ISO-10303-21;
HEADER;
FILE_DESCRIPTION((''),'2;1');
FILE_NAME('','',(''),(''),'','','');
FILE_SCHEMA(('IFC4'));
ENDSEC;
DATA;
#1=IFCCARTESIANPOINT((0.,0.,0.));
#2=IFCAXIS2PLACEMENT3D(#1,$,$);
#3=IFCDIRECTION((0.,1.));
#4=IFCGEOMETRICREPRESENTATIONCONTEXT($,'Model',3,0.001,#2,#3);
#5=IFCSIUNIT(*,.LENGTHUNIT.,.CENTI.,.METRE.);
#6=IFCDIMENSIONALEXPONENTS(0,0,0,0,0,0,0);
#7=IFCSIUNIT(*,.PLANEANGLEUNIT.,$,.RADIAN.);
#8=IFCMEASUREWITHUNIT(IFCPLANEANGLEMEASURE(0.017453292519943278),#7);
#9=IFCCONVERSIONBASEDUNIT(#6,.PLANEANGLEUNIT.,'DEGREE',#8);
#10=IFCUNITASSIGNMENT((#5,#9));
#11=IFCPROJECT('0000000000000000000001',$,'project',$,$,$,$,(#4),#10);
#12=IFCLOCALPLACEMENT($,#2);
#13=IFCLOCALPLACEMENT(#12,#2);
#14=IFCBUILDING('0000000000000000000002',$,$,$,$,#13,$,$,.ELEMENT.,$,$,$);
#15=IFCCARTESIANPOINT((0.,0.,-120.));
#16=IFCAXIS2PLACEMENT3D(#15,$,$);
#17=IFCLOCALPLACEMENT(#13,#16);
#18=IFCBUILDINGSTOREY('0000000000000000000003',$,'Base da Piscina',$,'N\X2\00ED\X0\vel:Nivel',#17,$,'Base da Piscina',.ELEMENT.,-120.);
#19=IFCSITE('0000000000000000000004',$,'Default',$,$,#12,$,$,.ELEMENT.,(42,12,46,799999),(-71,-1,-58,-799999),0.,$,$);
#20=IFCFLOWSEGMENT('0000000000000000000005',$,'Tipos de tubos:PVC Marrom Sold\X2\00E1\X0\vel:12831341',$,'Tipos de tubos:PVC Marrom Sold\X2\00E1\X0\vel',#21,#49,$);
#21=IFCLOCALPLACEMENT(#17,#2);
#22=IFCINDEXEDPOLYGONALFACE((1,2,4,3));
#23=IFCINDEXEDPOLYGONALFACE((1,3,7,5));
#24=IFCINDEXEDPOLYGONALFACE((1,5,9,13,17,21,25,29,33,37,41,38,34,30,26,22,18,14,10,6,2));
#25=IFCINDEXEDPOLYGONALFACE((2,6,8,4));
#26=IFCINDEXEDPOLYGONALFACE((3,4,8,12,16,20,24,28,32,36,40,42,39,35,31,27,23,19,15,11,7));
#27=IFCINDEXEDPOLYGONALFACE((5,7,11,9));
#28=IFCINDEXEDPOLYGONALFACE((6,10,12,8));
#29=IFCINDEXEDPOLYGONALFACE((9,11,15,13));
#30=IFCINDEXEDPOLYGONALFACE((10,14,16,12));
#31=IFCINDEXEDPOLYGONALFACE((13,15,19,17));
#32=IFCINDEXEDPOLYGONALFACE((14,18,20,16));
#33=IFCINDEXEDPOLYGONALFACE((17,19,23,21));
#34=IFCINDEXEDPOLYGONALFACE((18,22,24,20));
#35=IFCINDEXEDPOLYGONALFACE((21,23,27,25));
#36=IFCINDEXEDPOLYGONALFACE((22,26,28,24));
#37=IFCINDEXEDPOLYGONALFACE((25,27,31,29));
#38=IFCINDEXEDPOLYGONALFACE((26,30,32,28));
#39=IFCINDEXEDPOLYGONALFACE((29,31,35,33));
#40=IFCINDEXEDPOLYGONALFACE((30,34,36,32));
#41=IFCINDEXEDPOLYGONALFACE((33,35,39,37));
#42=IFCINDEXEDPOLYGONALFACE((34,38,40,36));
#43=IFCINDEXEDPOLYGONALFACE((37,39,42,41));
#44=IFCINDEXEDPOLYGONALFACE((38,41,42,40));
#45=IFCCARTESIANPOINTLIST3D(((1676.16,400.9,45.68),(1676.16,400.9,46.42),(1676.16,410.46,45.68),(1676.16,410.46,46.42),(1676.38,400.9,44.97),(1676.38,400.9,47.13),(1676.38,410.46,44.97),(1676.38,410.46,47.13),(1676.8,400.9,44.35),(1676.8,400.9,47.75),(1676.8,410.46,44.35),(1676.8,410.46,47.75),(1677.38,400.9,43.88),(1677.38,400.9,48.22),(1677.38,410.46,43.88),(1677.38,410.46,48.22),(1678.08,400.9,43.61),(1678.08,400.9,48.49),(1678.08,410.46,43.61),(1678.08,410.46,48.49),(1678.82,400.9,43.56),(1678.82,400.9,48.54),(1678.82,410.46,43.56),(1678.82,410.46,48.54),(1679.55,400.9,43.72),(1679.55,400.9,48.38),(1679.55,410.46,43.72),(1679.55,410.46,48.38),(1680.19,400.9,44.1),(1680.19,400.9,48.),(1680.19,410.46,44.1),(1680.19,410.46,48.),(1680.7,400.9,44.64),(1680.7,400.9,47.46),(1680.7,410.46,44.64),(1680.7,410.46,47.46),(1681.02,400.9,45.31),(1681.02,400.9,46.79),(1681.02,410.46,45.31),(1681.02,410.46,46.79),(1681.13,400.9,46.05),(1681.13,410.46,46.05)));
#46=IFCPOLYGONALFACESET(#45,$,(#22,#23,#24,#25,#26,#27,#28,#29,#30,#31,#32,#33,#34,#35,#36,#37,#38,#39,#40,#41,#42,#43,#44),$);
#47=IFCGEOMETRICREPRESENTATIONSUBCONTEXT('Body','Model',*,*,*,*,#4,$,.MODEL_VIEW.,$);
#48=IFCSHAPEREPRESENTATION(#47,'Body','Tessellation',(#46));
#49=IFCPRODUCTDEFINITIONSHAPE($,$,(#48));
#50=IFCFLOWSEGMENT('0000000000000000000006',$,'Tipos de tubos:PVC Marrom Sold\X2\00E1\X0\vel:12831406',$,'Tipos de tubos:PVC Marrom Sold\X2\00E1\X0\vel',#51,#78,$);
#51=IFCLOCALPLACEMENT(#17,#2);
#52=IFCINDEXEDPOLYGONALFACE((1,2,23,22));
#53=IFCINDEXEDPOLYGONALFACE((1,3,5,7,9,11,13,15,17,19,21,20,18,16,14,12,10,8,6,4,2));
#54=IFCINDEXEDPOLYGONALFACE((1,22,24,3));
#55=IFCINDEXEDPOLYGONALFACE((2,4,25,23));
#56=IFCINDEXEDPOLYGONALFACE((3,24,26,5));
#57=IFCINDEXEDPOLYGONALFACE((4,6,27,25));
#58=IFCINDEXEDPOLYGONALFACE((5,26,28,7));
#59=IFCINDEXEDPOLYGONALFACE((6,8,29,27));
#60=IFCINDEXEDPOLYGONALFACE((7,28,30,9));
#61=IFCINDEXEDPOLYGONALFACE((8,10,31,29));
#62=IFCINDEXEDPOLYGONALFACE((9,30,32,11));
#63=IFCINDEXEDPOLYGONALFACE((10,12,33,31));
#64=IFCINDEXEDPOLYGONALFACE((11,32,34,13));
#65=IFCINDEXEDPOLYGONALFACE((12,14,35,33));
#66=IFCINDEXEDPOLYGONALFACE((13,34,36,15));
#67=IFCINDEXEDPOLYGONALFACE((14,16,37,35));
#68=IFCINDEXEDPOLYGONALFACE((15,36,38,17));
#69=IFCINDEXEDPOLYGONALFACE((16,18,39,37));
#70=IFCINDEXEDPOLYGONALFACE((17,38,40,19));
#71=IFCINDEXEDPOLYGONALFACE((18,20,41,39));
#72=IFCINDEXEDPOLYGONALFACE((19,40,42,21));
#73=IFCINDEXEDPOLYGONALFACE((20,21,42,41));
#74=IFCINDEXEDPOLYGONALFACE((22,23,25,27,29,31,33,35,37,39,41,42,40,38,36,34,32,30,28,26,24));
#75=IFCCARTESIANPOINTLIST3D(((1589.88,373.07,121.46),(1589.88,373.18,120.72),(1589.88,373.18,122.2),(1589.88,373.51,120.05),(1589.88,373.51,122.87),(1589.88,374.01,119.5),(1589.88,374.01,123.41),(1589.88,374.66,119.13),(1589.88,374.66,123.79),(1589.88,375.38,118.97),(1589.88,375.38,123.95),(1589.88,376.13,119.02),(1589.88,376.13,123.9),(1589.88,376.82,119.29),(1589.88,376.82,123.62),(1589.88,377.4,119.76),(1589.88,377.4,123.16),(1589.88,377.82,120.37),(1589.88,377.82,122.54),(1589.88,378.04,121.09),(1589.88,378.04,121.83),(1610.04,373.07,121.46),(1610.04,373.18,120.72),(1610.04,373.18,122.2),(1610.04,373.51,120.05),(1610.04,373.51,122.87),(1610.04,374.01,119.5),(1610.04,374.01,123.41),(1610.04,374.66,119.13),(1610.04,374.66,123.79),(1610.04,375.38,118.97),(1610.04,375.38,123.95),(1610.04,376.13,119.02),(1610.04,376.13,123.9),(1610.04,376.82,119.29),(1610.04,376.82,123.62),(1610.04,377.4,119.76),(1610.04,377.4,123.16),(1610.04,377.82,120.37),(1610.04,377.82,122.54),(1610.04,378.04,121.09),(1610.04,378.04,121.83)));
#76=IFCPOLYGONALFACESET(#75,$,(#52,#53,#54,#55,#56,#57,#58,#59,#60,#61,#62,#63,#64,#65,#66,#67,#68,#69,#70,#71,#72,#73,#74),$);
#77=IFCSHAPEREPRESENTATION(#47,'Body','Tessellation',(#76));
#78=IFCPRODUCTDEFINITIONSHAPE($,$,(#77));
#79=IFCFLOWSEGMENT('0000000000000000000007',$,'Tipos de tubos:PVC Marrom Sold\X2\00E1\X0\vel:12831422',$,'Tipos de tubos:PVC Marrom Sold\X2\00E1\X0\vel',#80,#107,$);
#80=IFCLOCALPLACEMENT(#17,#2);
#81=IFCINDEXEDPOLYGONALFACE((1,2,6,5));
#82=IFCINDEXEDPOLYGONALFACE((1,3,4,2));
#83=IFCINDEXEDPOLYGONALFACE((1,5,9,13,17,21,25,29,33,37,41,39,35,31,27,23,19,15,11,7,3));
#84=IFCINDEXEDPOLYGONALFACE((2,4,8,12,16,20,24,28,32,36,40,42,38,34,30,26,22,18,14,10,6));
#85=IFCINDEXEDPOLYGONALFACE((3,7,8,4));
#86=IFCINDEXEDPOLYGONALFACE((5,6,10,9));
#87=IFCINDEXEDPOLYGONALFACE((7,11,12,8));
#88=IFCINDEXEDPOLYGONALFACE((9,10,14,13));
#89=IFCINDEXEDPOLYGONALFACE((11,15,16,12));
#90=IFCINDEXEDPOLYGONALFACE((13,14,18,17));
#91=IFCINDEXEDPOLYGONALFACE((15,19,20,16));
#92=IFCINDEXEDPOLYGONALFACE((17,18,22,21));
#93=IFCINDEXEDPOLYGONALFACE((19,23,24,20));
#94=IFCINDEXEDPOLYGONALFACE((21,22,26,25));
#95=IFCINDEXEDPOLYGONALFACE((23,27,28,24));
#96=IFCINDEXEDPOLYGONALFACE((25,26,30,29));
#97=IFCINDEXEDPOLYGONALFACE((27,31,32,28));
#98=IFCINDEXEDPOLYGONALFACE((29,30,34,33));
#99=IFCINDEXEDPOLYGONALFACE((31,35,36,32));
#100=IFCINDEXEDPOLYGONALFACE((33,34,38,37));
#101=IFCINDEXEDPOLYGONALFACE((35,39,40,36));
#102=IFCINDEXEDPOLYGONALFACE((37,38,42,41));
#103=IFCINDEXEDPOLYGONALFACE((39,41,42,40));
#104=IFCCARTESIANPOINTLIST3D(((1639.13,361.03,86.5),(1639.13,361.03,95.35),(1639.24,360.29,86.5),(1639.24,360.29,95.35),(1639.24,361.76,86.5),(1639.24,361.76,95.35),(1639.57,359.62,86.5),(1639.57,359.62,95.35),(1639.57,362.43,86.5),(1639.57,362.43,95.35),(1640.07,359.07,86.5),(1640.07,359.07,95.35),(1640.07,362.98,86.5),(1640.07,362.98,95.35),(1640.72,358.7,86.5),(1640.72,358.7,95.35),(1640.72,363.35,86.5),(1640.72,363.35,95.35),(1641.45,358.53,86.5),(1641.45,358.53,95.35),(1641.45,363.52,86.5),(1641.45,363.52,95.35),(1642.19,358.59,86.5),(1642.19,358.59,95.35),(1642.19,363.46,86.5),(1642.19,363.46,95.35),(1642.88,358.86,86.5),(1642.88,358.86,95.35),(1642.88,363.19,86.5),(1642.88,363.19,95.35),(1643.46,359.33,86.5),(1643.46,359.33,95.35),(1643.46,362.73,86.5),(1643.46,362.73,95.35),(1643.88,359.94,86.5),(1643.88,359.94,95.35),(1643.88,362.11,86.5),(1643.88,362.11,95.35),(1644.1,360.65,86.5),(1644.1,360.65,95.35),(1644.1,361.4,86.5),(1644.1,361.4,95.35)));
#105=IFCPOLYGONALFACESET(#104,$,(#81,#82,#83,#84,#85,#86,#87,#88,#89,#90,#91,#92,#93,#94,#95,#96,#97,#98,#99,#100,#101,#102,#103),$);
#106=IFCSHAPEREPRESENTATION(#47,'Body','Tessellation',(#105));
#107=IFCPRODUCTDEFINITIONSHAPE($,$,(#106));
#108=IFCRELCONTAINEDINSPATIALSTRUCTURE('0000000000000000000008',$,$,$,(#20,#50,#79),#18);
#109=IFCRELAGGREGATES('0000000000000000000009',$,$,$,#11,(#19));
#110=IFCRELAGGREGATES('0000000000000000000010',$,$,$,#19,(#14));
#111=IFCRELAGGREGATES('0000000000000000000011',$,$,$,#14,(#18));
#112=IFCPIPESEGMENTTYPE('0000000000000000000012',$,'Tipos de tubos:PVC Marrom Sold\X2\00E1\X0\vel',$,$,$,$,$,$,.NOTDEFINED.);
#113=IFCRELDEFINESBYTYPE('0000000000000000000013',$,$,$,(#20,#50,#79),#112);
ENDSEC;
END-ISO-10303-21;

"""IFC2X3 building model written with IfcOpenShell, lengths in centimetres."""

from ifc_helpers import new_model, entity, si_unit, converted_unit, direction, frame, frame_2d, origin, origin_2d_with_axis, place, context, subcontext, project, spatial, circle, extrude, type_object, element, save


model = new_model("IFC2X3")

# Units and contexts
model_context = context("Model", 3, precision=0.001, world=origin(), true_north=direction((0.0, 1.0)))
body_context = subcontext(model_context, "Body", "Model", "MODEL_VIEW")
ifc_project = project(units=[si_unit("LENGTHUNIT", "METRE", prefix="CENTI"), converted_unit("PLANEANGLEUNIT", "DEGREE", entity("IfcPlaneAngleMeasure", 0.017453292519943278), si_unit("PLANEANGLEUNIT", "RADIAN"), dimensions=[0, 0, 0, 0, 0, 0, 0])], contexts=[model_context])

# Site, building, storey
site_placement = place(None, origin())
site = spatial("IfcSite", under=ifc_project, at=site_placement, Name="Default", CompositionType="ELEMENT", RefLatitude=(42, 12, 46, 799999), RefLongitude=(-71, -1, -58, -799999), RefElevation=0.0)
building_placement = place(site_placement, origin())
building = spatial("IfcBuilding", under=site, at=building_placement, CompositionType="ELEMENT")
storey_placement = place(building_placement, frame((0.0, 0.0, -120.0)))
storey = spatial("IfcBuildingStorey", under=building, at=storey_placement, Name="Base da Piscina", ObjectType="Nível:Nivel", LongName="Base da Piscina", CompositionType="ELEMENT", Elevation=-120.0)

# Flow segments
pipe_segment_type = type_object("IfcPipeSegmentType", Name="Tipos de tubos:PVC Marrom Soldável", PredefinedType="NOTDEFINED")
flow_segment_1_placement = place(storey_placement, origin())
element("IfcFlowSegment", 1, at=flow_segment_1_placement, inside=storey, type_object=pipe_segment_type, Name="Tipos de tubos:PVC Marrom Soldável:12831341", ObjectType="Tipos de tubos:PVC Marrom Soldável", context=body_context, shape_type="SweptSolid", body=[
    extrude(circle(Radius=2.5, at=origin_2d_with_axis()), frame((1678.63, 400.9, 46.05), z_axis=(0.0, 1.0, 0.0), x_axis=(1.0, 0.0, 0.0)), (0.0, 0.0, 1.0), 9.56),
])
flow_segment_2_placement = place(storey_placement, origin())
element("IfcFlowSegment", 2, at=flow_segment_2_placement, inside=storey, type_object=pipe_segment_type, Name="Tipos de tubos:PVC Marrom Soldável:12831406", ObjectType="Tipos de tubos:PVC Marrom Soldável", context=body_context, shape_type="SweptSolid", body=[
    extrude(circle(Radius=2.5, at=frame_2d((0.0, 0.0), x_axis=(1.0, 0.0))), frame((1589.88, 375.57, 121.46), z_axis=(1.0, 0.0, 0.0), x_axis=(0.0, -1.0, 0.0)), (0.0, 0.0, 1.0), 20.16),
])
flow_segment_3_placement = place(storey_placement, origin())
element("IfcFlowSegment", 3, at=flow_segment_3_placement, inside=storey, type_object=pipe_segment_type, Name="Tipos de tubos:PVC Marrom Soldável:12831422", ObjectType="Tipos de tubos:PVC Marrom Soldável", context=body_context, shape_type="SweptSolid", body=[
    extrude(circle(Radius=2.5, at=origin_2d_with_axis()), frame((1641.63, 361.03, 86.5), z_axis=(0.0, 0.0, 1.0), x_axis=(-1.0, 0.0, 0.0)), (0.0, 0.0, 1.0), 8.86),
])

save(model, "model.ifc")
